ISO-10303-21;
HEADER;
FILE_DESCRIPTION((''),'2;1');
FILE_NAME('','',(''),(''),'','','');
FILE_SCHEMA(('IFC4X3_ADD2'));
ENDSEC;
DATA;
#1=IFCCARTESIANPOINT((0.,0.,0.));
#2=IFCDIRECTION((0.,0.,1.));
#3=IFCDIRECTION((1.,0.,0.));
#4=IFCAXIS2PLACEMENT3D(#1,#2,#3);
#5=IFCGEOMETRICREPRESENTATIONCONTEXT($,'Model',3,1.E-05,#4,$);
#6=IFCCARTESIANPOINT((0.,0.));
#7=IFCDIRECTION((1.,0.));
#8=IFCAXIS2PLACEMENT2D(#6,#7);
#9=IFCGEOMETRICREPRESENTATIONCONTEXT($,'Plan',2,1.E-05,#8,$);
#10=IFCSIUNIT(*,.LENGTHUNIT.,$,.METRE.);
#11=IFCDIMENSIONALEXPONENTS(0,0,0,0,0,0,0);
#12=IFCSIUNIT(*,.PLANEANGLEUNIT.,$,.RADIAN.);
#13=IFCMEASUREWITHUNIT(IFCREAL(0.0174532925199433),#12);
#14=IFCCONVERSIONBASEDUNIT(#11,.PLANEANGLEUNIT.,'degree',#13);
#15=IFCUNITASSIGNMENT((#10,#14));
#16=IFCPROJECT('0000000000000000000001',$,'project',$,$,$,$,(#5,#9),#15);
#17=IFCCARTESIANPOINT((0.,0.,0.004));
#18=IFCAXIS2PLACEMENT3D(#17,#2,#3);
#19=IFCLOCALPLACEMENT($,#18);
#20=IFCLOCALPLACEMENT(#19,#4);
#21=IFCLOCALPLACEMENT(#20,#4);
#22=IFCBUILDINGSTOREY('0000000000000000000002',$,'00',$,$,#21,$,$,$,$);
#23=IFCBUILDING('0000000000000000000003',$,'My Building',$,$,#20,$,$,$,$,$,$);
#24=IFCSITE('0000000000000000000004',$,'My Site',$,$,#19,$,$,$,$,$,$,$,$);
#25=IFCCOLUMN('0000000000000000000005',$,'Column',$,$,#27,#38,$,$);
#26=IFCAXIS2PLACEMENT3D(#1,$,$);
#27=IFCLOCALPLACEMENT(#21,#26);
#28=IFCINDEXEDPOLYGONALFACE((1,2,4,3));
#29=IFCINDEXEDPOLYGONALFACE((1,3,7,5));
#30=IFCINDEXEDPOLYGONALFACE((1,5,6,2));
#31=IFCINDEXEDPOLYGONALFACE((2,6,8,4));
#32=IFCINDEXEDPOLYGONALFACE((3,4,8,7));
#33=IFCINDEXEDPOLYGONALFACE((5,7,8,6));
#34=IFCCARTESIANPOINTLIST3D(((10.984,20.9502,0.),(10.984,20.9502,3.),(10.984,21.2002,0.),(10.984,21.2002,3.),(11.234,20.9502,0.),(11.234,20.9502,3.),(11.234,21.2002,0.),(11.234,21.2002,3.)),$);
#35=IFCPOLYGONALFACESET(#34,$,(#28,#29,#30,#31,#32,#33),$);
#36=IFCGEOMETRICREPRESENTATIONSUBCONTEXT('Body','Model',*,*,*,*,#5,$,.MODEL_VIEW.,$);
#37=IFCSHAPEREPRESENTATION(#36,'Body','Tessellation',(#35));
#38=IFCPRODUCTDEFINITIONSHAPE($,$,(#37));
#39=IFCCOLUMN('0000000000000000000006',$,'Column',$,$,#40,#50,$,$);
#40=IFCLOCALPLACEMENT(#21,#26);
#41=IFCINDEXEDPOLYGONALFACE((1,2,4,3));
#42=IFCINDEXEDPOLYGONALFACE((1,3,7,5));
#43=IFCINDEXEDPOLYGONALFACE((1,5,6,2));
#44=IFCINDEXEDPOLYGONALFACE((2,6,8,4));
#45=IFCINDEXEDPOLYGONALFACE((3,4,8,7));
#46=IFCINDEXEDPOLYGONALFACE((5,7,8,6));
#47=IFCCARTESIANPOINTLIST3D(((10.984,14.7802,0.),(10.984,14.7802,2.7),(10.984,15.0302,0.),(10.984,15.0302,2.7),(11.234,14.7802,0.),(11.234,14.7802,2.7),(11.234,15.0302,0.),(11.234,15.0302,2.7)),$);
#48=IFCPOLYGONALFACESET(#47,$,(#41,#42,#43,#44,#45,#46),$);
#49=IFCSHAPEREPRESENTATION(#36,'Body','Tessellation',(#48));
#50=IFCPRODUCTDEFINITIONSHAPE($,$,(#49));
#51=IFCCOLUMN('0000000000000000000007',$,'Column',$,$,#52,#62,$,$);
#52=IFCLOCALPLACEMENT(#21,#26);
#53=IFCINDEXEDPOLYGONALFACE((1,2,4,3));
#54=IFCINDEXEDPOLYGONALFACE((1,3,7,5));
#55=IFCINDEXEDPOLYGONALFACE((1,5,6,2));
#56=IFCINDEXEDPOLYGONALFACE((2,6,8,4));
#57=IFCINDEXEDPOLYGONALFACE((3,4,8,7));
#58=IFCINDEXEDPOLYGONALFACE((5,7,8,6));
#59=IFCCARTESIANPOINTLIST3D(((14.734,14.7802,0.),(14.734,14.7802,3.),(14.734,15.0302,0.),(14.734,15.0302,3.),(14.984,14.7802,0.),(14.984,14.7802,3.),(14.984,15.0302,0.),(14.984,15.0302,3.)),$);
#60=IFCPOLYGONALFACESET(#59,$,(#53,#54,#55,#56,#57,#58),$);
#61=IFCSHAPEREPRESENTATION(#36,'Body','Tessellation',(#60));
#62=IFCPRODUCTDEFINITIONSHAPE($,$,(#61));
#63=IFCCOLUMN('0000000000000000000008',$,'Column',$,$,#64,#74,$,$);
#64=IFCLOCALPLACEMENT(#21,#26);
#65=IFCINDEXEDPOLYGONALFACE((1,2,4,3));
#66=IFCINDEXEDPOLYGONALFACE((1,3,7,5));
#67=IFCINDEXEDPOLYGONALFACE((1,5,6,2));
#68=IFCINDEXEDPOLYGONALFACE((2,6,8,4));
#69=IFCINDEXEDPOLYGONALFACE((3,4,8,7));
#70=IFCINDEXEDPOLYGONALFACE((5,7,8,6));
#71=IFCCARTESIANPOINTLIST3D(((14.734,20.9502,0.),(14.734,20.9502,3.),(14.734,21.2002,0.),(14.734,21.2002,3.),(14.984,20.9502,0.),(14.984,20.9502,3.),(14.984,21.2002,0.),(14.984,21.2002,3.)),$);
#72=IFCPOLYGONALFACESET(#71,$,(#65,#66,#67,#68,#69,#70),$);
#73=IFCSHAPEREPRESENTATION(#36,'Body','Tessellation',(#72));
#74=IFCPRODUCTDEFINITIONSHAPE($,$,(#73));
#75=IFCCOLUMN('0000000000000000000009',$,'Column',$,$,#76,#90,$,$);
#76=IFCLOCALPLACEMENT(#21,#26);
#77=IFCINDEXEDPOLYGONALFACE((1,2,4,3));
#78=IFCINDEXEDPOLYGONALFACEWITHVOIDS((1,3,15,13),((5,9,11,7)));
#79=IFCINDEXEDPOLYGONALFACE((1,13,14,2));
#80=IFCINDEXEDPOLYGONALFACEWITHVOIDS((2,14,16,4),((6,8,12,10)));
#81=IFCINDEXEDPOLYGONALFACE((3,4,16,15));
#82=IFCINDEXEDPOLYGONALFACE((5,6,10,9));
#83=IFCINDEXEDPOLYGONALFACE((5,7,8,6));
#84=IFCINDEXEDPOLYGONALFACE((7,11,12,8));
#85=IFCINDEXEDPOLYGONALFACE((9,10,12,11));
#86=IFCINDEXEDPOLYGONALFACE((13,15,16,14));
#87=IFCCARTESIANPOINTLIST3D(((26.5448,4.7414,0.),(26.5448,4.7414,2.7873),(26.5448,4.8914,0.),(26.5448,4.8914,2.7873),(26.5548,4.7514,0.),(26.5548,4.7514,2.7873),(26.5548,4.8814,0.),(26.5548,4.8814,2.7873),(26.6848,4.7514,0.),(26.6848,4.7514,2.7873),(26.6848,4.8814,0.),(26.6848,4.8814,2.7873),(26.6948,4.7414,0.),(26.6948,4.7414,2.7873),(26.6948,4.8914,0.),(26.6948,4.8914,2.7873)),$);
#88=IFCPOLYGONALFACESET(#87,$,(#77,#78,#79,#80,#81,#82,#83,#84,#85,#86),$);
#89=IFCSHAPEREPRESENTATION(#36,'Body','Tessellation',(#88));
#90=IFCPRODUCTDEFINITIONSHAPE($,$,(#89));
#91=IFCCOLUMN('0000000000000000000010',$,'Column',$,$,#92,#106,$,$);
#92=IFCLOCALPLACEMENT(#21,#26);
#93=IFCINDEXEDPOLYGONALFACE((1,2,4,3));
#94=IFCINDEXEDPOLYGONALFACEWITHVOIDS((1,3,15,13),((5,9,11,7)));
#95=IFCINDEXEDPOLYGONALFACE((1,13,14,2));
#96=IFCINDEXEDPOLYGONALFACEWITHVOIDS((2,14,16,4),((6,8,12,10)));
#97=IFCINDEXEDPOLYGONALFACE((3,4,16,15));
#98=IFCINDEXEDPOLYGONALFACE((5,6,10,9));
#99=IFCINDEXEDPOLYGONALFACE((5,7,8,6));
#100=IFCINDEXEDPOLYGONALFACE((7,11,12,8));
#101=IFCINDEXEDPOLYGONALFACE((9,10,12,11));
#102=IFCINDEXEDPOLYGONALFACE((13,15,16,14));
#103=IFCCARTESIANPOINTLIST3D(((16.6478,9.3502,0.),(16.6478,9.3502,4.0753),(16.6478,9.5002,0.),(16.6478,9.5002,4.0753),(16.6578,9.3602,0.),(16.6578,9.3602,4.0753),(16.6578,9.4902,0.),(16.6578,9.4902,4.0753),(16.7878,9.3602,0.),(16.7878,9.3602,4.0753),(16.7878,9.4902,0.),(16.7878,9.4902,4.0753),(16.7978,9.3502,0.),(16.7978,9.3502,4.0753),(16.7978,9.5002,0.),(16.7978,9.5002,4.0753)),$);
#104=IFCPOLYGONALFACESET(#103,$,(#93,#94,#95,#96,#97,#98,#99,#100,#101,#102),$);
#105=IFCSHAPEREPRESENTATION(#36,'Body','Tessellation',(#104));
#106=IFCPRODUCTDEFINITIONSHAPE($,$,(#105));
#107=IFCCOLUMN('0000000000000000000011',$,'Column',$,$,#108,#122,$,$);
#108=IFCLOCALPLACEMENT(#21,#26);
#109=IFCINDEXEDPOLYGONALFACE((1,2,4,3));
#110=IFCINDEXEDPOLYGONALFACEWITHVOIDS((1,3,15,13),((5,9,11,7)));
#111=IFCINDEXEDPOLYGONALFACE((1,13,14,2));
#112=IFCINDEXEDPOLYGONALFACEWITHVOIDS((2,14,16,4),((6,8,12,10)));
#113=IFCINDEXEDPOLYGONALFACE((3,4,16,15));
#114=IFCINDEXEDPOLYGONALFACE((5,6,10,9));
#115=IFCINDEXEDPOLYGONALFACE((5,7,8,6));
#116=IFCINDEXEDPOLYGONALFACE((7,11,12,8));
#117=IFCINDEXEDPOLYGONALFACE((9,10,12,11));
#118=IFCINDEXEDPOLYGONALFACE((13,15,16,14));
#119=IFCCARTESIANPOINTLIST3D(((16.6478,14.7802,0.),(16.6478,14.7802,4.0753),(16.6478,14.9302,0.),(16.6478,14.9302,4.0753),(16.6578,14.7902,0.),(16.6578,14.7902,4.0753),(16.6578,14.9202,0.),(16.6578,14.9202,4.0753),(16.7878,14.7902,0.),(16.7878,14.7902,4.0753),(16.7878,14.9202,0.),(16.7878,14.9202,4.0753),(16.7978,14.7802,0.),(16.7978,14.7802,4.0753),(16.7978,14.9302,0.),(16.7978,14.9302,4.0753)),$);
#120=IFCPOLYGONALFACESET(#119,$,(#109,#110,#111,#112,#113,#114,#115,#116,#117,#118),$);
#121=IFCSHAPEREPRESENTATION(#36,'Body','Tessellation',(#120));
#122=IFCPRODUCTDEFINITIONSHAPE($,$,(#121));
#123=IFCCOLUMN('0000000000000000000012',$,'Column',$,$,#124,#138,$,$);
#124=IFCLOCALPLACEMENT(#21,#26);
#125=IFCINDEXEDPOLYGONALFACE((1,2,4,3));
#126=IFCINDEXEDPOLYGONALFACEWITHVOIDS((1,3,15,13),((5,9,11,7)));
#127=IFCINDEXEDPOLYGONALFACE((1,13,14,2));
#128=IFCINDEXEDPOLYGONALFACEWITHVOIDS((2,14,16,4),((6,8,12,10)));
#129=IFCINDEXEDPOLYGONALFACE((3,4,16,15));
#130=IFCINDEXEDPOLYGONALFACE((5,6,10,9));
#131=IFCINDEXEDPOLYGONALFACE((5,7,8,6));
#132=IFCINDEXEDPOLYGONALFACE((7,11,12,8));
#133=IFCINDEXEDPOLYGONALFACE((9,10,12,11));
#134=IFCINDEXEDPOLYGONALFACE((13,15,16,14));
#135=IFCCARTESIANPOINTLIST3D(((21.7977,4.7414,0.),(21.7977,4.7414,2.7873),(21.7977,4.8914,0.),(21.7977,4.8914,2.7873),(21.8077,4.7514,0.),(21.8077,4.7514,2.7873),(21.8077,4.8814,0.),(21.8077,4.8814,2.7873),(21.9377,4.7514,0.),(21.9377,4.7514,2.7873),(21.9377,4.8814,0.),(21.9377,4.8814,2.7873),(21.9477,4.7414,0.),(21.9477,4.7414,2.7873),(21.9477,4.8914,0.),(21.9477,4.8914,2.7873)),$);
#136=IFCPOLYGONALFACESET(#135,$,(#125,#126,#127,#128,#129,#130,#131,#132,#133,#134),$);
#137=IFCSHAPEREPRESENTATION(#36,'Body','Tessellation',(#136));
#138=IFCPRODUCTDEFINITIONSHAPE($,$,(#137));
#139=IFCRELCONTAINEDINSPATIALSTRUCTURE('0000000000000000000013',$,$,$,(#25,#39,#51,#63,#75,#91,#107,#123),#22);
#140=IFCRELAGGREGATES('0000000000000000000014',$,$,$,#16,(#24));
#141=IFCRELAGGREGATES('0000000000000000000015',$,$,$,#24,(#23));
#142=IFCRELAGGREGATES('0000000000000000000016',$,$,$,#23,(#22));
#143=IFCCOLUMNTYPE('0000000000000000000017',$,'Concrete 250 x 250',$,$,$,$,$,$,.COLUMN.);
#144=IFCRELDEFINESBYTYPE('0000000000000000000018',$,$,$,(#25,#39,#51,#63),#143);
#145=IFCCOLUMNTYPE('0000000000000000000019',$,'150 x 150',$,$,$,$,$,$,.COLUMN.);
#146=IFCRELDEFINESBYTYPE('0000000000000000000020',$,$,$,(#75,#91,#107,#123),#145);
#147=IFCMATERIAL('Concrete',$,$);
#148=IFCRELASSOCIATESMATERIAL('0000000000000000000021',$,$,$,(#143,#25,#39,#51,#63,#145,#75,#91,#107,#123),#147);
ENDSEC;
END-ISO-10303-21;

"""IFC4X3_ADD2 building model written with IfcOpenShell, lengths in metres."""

from ifc_helpers import new_model, entity, si_unit, converted_unit, frame, origin_with_axes, origin_2d_with_axis, place, context, subcontext, project, spatial, rectangle, hollow_rectangle, extrude, material, material_profile, profile_set, profile_usage, type_object, element, save


model = new_model("IFC4X3_ADD2")

# Units and contexts
model_context = context("Model", 3, precision=1e-05, world=origin_with_axes())
plan_context = context("Plan", 2, precision=1e-05, world=origin_2d_with_axis())
body_context = subcontext(model_context, "Body", "Model", "MODEL_VIEW")
ifc_project = project(units=[si_unit("LENGTHUNIT", "METRE"), converted_unit("PLANEANGLEUNIT", "degree", entity("IfcReal", 0.0174532925199433), si_unit("PLANEANGLEUNIT", "RADIAN"), dimensions=[0, 0, 0, 0, 0, 0, 0])], contexts=[model_context, plan_context])

# Site, building, storey
site_placement = place(None, frame((0.0, 0.0, 0.004), z_axis=(0.0, 0.0, 1.0), x_axis=(1.0, 0.0, 0.0)))
site = spatial("IfcSite", under=ifc_project, at=site_placement, Name="My Site")
building_placement = place(site_placement, origin_with_axes())
building = spatial("IfcBuilding", under=site, at=building_placement, Name="My Building")
storey_placement = place(building_placement, origin_with_axes())
storey = spatial("IfcBuildingStorey", under=building, at=storey_placement, Name="00")

# Columns
ifc_material_1 = material(Name="Concrete")
ifc_material_profile_1 = material_profile(ifc_material_1, rectangle(XDim=0.25, YDim=0.25))
ifc_profile_set_1 = profile_set([ifc_material_profile_1])
ifc_profile_usage_1 = profile_usage(ifc_profile_set_1, cardinal=5)
column_type_1 = type_object("IfcColumnType", Name="Concrete 250 x 250", PredefinedType="COLUMN", material=ifc_profile_set_1)
column_1_placement = place(storey_placement, frame((11.109, 21.0752, 0.0), z_axis=(0.0, 0.0, 1.0), x_axis=(1.0, 0.0, 0.0)))
element("IfcColumn", 1, at=column_1_placement, inside=storey, type_object=column_type_1, material=ifc_profile_usage_1, Name="Column", context=body_context, shape_type="SweptSolid", body=[
    extrude(rectangle(XDim=0.25, YDim=0.25), origin_with_axes(), (0.0, 0.0, 1.0), 3.0),
])
ifc_profile_usage_2 = profile_usage(ifc_profile_set_1, cardinal=5)
column_2_placement = place(storey_placement, frame((11.109, 14.9052, 0.0), z_axis=(0.0, 0.0, 1.0), x_axis=(1.0, 0.0, 0.0)))
element("IfcColumn", 2, at=column_2_placement, inside=storey, type_object=column_type_1, material=ifc_profile_usage_2, Name="Column", context=body_context, shape_type="SweptSolid", body=[
    extrude(rectangle(XDim=0.25, YDim=0.25), origin_with_axes(), (0.0, 0.0, 1.0), 2.7),
])
ifc_profile_usage_3 = profile_usage(ifc_profile_set_1, cardinal=5)
column_3_placement = place(storey_placement, frame((14.859, 14.9052, 0.0), z_axis=(0.0, 0.0, 1.0), x_axis=(1.0, 0.0, 0.0)))
element("IfcColumn", 3, at=column_3_placement, inside=storey, type_object=column_type_1, material=ifc_profile_usage_3, Name="Column", context=body_context, shape_type="SweptSolid", body=[
    extrude(rectangle(XDim=0.25, YDim=0.25), origin_with_axes(), (0.0, 0.0, 1.0), 3.0),
])
ifc_profile_usage_4 = profile_usage(ifc_profile_set_1, cardinal=5)
column_4_placement = place(storey_placement, frame((14.859, 21.0752, 0.0), z_axis=(0.0, 0.0, 1.0), x_axis=(1.0, 0.0, 0.0)))
element("IfcColumn", 4, at=column_4_placement, inside=storey, type_object=column_type_1, material=ifc_profile_usage_4, Name="Column", context=body_context, shape_type="SweptSolid", body=[
    extrude(rectangle(XDim=0.25, YDim=0.25), origin_with_axes(), (0.0, 0.0, 1.0), 3.0),
])
ifc_material_profile_2 = material_profile(ifc_material_1, hollow_rectangle(XDim=0.15, YDim=0.15, WallThickness=0.01))
ifc_profile_set_2 = profile_set([ifc_material_profile_2])
ifc_profile_usage_5 = profile_usage(ifc_profile_set_2, cardinal=5)
column_type_2 = type_object("IfcColumnType", Name="150 x 150", PredefinedType="COLUMN", material=ifc_profile_set_2)
column_5_placement = place(storey_placement, frame((26.6198, 4.8164, 0.0), z_axis=(0.0, 0.0, 1.0), x_axis=(1.0, 0.0, 0.0)))
element("IfcColumn", 5, at=column_5_placement, inside=storey, type_object=column_type_2, material=ifc_profile_usage_5, Name="Column", context=body_context, shape_type="SweptSolid", body=[
    extrude(hollow_rectangle(XDim=0.15, YDim=0.15, WallThickness=0.01), origin_with_axes(), (0.0, 0.0, 1.0), 2.7873),
])
ifc_profile_usage_6 = profile_usage(ifc_profile_set_2, cardinal=5)
column_6_placement = place(storey_placement, frame((16.7228, 9.4252, 0.0), z_axis=(0.0, 0.0, 1.0), x_axis=(1.0, 0.0, 0.0)))
element("IfcColumn", 6, at=column_6_placement, inside=storey, type_object=column_type_2, material=ifc_profile_usage_6, Name="Column", context=body_context, shape_type="SweptSolid", body=[
    extrude(hollow_rectangle(XDim=0.15, YDim=0.15, WallThickness=0.01), origin_with_axes(), (0.0, 0.0, 1.0), 4.0753),
])
ifc_profile_usage_7 = profile_usage(ifc_profile_set_2, cardinal=5)
column_7_placement = place(storey_placement, frame((16.7228, 14.8552, 0.0), z_axis=(0.0, 0.0, 1.0), x_axis=(1.0, 0.0, 0.0)))
element("IfcColumn", 7, at=column_7_placement, inside=storey, type_object=column_type_2, material=ifc_profile_usage_7, Name="Column", context=body_context, shape_type="SweptSolid", body=[
    extrude(hollow_rectangle(XDim=0.15, YDim=0.15, WallThickness=0.01), origin_with_axes(), (0.0, 0.0, 1.0), 4.0753),
])
ifc_profile_usage_8 = profile_usage(ifc_profile_set_2, cardinal=5)
column_8_placement = place(storey_placement, frame((21.8727, 4.8164, 0.0), z_axis=(0.0, 0.0, 1.0), x_axis=(1.0, 0.0, 0.0)))
element("IfcColumn", 8, at=column_8_placement, inside=storey, type_object=column_type_2, material=ifc_profile_usage_8, Name="Column", context=body_context, shape_type="SweptSolid", body=[
    extrude(hollow_rectangle(XDim=0.15, YDim=0.15, WallThickness=0.01), origin_with_axes(), (0.0, 0.0, 1.0), 2.7873),
])

save(model, "model.ifc")
